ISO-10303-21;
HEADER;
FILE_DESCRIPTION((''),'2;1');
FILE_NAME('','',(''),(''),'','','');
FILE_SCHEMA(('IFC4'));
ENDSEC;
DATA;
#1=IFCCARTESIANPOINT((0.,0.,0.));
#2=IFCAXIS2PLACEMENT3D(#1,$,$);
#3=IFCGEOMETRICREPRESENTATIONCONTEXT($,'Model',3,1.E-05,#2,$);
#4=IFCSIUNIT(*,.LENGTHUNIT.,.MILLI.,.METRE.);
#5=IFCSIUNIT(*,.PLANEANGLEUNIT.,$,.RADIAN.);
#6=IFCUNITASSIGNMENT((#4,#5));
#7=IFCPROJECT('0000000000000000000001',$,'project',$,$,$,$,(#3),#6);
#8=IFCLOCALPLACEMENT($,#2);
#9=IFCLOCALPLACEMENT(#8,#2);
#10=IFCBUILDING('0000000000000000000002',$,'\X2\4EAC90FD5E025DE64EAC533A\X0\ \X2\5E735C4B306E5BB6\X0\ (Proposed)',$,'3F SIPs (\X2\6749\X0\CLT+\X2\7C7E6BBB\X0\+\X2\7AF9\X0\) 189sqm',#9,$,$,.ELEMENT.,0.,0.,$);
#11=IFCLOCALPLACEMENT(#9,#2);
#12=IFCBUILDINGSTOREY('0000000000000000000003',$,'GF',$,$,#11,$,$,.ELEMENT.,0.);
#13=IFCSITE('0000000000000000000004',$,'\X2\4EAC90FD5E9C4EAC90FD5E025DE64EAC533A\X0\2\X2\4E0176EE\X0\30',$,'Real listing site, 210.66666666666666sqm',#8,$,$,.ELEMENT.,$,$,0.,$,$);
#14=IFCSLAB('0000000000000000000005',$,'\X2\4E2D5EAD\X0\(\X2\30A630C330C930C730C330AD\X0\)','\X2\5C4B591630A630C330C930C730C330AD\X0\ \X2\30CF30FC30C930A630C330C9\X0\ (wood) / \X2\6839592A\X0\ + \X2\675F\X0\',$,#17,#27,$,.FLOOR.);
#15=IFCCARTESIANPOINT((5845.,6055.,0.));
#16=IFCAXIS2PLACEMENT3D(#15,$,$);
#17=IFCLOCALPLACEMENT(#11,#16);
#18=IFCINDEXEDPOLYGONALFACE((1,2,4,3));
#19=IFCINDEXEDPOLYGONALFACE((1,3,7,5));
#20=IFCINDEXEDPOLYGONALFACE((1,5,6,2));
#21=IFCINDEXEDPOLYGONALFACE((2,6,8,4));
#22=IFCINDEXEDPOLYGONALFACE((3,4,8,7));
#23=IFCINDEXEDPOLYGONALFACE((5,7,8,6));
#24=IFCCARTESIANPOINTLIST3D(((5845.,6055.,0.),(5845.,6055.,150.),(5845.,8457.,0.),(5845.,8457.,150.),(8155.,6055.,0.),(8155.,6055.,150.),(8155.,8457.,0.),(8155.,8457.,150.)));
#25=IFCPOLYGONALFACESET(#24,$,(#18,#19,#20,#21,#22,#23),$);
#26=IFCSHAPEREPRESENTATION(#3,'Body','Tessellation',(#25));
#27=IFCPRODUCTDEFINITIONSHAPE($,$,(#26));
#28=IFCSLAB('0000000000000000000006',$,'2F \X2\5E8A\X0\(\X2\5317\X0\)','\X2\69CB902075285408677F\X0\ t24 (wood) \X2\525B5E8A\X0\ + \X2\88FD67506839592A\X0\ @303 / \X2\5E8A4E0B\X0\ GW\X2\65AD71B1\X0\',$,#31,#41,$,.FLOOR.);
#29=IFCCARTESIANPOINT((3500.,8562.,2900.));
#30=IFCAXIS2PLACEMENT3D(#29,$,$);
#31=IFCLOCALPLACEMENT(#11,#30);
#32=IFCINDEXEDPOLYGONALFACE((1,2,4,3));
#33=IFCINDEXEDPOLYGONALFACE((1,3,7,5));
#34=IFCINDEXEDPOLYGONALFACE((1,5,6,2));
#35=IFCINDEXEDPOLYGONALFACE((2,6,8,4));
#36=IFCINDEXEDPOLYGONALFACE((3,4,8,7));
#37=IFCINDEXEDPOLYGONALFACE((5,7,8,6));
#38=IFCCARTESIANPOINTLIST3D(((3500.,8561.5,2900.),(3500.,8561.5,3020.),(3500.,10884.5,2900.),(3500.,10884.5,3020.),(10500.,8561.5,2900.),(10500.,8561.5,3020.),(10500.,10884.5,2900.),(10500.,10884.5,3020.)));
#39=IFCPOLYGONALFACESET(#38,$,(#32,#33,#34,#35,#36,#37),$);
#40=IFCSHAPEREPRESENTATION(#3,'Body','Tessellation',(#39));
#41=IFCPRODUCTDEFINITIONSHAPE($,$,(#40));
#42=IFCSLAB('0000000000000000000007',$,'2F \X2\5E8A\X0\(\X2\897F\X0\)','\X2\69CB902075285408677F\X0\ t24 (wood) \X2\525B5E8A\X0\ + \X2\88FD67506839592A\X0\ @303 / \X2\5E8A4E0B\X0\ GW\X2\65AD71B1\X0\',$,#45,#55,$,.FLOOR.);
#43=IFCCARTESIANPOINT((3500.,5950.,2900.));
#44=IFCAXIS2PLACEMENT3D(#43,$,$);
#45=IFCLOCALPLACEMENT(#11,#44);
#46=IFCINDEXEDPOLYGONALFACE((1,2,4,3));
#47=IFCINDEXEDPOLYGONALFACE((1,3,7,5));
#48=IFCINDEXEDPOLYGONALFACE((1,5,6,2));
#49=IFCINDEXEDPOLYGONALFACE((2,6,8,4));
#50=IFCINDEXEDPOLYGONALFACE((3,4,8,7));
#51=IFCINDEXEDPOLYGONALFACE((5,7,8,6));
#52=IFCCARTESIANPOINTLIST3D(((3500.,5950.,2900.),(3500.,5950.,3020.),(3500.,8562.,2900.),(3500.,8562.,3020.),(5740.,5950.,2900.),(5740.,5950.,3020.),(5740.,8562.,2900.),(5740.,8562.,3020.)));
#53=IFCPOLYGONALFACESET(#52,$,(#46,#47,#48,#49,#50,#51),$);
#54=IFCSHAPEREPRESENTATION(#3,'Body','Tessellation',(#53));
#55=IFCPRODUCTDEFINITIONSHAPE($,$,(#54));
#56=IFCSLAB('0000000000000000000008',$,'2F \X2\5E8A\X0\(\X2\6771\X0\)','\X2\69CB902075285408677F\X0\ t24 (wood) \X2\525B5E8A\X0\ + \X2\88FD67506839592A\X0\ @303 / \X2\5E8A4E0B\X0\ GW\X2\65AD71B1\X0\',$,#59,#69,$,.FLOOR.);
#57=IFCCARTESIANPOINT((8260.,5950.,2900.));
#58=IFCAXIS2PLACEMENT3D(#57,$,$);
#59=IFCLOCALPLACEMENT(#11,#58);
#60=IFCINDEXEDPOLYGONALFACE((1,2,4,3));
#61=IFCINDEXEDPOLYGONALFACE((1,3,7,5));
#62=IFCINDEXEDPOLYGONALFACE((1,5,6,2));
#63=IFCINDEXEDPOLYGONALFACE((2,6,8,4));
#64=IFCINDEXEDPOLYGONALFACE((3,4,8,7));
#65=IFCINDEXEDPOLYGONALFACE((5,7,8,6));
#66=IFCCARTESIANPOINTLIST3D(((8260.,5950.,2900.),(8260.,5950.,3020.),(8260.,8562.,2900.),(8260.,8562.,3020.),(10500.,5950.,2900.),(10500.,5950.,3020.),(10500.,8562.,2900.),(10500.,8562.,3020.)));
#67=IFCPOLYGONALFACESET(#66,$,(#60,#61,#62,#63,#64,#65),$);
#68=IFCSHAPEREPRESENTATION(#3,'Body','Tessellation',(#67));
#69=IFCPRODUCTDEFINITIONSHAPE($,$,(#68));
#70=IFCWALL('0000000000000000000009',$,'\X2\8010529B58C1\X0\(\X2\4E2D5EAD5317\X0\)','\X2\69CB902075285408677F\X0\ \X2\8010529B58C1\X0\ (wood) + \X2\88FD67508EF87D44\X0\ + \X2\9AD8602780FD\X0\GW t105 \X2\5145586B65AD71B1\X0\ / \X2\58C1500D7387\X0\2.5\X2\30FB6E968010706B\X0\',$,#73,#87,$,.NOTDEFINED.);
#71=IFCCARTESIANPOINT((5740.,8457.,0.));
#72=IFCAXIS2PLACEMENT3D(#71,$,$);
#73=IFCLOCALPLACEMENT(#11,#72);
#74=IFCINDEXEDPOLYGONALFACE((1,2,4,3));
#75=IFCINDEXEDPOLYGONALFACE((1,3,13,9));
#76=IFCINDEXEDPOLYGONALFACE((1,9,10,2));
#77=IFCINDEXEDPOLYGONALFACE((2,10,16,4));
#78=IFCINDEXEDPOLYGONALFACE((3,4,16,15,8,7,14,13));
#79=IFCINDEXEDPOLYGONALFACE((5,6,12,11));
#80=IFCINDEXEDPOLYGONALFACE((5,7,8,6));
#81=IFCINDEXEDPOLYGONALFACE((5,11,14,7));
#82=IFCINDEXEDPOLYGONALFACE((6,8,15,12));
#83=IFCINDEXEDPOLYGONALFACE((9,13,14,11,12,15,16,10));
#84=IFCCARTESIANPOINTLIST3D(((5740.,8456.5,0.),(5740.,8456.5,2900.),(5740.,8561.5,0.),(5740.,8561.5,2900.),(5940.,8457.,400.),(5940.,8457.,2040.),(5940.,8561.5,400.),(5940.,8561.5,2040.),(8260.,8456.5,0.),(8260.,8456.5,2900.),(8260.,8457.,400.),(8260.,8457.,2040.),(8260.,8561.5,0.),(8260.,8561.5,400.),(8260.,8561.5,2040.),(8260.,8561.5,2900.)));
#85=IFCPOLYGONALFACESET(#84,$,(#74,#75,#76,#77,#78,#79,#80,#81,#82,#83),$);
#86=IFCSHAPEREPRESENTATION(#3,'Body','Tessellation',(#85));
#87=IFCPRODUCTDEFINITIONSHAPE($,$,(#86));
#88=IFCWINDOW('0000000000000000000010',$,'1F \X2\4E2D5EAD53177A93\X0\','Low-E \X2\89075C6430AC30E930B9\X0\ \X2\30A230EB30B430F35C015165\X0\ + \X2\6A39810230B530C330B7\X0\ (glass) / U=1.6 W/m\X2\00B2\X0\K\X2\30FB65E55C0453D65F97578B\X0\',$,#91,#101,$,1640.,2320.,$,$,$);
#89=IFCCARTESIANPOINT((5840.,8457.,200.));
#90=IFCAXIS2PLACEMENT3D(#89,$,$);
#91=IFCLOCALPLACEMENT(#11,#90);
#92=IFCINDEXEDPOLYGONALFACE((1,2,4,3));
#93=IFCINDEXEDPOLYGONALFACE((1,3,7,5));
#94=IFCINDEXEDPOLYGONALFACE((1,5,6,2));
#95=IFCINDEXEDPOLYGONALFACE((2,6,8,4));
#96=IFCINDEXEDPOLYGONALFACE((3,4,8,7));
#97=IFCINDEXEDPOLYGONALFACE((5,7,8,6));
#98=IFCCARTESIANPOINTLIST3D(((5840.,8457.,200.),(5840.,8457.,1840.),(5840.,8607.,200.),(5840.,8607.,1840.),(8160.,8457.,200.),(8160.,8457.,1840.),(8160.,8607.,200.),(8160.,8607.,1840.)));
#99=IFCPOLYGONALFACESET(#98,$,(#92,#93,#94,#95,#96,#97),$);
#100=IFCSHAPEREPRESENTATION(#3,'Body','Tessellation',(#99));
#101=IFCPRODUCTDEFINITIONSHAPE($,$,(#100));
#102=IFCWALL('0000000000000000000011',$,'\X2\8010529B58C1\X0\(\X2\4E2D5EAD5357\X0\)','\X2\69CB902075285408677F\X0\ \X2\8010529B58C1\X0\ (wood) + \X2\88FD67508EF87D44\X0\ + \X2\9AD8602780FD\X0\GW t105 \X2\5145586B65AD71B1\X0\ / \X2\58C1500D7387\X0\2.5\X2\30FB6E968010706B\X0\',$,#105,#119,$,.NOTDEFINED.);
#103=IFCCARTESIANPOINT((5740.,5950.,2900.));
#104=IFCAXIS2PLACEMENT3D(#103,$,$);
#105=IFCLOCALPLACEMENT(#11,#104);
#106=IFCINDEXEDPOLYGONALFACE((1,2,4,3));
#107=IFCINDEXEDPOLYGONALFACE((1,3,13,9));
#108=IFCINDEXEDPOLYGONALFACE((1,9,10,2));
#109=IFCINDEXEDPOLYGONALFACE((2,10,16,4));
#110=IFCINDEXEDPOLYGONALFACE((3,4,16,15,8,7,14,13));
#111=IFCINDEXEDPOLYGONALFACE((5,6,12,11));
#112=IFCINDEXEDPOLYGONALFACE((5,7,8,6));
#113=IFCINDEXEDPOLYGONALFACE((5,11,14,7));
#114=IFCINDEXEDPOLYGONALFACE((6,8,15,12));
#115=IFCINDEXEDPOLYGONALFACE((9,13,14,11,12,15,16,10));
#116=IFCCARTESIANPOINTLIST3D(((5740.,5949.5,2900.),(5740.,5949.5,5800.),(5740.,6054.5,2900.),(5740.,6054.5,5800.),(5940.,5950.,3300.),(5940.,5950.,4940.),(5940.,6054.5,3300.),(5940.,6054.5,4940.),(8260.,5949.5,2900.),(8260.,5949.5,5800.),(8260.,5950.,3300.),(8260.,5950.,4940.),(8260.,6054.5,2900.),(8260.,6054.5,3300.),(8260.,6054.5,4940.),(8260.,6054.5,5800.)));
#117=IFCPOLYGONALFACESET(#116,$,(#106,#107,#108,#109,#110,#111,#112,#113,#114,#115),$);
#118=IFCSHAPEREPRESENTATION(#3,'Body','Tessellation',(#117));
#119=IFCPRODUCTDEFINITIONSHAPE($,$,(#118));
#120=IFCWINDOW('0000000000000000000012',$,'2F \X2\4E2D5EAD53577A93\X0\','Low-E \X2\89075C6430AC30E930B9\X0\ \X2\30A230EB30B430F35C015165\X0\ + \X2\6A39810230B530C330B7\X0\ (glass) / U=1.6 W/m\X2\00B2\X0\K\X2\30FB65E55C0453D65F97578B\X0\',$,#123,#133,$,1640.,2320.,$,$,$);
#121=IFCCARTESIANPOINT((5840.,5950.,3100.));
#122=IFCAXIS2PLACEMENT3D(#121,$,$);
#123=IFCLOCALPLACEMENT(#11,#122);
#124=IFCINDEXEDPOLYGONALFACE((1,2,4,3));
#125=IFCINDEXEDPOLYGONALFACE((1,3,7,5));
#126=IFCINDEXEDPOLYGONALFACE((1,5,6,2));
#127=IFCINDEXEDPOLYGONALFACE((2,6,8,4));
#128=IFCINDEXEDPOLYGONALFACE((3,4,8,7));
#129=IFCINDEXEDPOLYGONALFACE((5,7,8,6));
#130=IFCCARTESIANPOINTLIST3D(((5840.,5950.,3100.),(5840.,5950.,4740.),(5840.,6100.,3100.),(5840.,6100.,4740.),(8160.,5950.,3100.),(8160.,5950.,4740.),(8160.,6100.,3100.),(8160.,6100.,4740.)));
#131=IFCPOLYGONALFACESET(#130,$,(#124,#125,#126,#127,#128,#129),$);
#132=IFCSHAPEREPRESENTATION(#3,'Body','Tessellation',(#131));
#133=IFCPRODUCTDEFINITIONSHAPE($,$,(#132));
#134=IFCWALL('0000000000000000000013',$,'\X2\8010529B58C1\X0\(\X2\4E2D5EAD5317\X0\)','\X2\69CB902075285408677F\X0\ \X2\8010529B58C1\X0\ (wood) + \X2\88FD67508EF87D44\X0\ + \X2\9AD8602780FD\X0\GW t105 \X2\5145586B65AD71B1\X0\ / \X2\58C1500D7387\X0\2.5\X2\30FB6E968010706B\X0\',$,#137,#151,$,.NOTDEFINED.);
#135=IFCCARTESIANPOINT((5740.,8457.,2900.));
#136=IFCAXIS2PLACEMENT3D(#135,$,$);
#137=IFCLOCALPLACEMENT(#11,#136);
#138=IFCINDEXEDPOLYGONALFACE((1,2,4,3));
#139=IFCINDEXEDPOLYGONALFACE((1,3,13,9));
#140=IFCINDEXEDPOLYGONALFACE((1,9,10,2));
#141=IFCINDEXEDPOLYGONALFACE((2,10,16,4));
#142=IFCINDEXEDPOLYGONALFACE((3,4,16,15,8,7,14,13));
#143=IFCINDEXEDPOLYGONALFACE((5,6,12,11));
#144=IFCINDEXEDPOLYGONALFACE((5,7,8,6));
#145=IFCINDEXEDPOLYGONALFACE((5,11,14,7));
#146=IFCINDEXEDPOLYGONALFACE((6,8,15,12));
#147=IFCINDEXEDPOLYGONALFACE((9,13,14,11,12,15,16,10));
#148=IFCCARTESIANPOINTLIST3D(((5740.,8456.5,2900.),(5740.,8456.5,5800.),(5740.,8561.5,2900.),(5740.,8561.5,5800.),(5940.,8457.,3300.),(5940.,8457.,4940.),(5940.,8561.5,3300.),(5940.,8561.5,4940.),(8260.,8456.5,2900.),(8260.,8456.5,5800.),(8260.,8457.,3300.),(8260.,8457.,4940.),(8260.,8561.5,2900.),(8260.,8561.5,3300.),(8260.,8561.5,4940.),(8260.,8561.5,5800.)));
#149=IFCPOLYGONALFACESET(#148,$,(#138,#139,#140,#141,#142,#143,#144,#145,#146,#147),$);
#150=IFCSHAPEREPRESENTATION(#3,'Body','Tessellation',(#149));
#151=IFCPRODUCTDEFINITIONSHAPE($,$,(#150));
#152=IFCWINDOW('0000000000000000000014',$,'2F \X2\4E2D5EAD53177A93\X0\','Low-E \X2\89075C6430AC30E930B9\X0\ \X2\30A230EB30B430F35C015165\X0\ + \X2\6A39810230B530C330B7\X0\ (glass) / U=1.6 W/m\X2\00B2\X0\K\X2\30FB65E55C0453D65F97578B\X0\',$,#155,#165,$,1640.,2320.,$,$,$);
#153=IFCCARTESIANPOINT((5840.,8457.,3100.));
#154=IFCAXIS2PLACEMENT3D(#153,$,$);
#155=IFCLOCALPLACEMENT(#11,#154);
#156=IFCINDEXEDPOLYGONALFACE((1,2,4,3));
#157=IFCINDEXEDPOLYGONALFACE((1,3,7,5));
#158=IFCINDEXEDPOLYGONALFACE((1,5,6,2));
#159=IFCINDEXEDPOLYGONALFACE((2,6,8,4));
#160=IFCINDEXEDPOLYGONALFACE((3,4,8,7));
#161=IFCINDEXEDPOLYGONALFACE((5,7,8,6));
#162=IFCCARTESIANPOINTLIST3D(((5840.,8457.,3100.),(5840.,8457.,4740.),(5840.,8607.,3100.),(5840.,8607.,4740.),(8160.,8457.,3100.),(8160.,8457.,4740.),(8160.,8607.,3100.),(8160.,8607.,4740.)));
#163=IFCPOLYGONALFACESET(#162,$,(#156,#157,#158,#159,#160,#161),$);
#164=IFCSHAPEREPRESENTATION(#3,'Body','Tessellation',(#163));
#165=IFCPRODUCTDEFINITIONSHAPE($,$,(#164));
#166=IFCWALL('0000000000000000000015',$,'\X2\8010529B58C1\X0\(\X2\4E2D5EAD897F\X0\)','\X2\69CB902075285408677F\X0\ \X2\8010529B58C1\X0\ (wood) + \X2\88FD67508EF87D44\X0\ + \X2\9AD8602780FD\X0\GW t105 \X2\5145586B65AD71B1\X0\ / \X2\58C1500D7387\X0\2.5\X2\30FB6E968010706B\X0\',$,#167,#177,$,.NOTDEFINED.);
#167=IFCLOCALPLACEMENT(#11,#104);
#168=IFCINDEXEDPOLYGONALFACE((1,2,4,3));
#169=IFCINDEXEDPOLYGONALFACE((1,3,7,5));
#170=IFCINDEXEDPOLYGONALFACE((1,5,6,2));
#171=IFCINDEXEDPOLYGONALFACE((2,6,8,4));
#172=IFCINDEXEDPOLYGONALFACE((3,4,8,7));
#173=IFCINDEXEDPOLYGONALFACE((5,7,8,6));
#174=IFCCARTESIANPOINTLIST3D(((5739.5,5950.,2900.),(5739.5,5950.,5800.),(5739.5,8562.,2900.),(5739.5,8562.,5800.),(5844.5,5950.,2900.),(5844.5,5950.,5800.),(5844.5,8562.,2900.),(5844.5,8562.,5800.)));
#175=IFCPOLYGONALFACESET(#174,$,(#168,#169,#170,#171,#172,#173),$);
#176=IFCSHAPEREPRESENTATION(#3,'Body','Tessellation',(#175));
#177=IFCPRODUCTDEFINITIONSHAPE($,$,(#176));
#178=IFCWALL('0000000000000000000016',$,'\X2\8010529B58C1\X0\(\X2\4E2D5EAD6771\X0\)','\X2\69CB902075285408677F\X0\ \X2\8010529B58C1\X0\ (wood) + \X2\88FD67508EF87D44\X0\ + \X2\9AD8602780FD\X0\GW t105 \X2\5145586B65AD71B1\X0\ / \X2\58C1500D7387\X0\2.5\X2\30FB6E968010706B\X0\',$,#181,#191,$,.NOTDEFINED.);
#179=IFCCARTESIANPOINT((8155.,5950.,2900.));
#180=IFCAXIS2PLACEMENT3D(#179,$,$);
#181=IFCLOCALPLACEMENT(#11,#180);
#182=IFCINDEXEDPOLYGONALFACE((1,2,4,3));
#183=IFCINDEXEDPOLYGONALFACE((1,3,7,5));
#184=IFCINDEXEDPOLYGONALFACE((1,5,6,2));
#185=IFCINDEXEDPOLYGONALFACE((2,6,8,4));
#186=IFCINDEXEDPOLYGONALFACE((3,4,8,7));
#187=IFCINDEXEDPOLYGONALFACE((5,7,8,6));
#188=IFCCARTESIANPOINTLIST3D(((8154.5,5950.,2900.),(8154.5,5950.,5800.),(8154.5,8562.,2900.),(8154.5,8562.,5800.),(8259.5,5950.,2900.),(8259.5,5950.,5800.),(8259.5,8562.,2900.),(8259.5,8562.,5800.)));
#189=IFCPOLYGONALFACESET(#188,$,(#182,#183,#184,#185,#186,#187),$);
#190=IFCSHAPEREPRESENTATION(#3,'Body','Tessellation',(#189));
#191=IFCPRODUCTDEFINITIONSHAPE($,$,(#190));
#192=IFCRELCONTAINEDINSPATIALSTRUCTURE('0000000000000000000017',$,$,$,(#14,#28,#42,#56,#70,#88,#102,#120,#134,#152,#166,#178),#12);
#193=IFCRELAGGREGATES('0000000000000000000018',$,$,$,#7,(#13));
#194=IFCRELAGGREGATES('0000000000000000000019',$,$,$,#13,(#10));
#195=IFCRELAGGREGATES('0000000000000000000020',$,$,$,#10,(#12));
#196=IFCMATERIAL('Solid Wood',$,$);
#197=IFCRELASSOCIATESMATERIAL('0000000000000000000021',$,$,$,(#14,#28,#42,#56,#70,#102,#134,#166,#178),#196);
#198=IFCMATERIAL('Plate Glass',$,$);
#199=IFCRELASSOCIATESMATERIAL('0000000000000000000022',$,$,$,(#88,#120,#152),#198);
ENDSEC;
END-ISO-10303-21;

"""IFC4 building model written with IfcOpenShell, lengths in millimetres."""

from ifc_helpers import new_model, si_unit, frame, frame_2d, origin, place, context, project, spatial, rectangle, extrude, material, element, fill, save


model = new_model("IFC4")

# Units and contexts
model_context = context("Model", 3, precision=1e-05, world=origin())
ifc_project = project(units=[si_unit("LENGTHUNIT", "METRE", prefix="MILLI"), si_unit("PLANEANGLEUNIT", "RADIAN")], contexts=[model_context])

# Site, building, storey
site_placement = place(None, origin())
site = spatial("IfcSite", under=ifc_project, at=site_placement, Name="京都府京都市左京区2丁目30", ObjectType="Real listing site, 210.66666666666666sqm", CompositionType="ELEMENT", RefElevation=0.0)
building_placement = place(site_placement, origin())
building = spatial("IfcBuilding", under=site, at=building_placement, Name="京都市左京区 平屋の家 (Proposed)", ObjectType="3F SIPs (杉CLT+籾殻+竹) 189sqm", CompositionType="ELEMENT", ElevationOfRefHeight=0.0, ElevationOfTerrain=0.0)
storey_placement = place(building_placement, origin())
storey = spatial("IfcBuildingStorey", under=building, at=storey_placement, Name="GF", CompositionType="ELEMENT", Elevation=0.0)

# Slabs
ifc_material_1 = material(Name="Solid Wood")
slab_1_placement = place(storey_placement, frame((5845.0, 6055.0, 0.0)))
element("IfcSlab", 1, at=slab_1_placement, inside=storey, material=ifc_material_1, Name="中庭(ウッドデッキ)", Description="屋外ウッドデッキ ハードウッド (wood) / 根太 + 束", PredefinedType="FLOOR", context=model_context, shape_type="SweptSolid", body=[
    extrude(rectangle(XDim=2310.0, YDim=2402.0, at=frame_2d((1155.0, 1201.0))), frame((5845.0, 6055.0, 0.0)), (0.0, 0.0, 1.0), 150.0),
])
slab_2_placement = place(storey_placement, frame((3500.0, 8562.0, 2900.0)))
element("IfcSlab", 2, at=slab_2_placement, inside=storey, material=ifc_material_1, Name="2F 床(北)", Description="構造用合板 t24 (wood) 剛床 + 製材根太 @303 / 床下 GW断熱", PredefinedType="FLOOR", context=model_context, shape_type="SweptSolid", body=[
    extrude(rectangle(XDim=7000.0, YDim=2323.0, at=frame_2d((3500.0, 1161.0))), frame((3500.0, 8562.0, 2900.0)), (0.0, 0.0, 1.0), 120.0),
])
slab_3_placement = place(storey_placement, frame((3500.0, 5950.0, 2900.0)))
element("IfcSlab", 3, at=slab_3_placement, inside=storey, material=ifc_material_1, Name="2F 床(西)", Description="構造用合板 t24 (wood) 剛床 + 製材根太 @303 / 床下 GW断熱", PredefinedType="FLOOR", context=model_context, shape_type="SweptSolid", body=[
    extrude(rectangle(XDim=2240.0, YDim=2612.0, at=frame_2d((1120.0, 1306.0))), frame((3500.0, 5950.0, 2900.0)), (0.0, 0.0, 1.0), 120.0),
])
slab_4_placement = place(storey_placement, frame((8260.0, 5950.0, 2900.0)))
element("IfcSlab", 4, at=slab_4_placement, inside=storey, material=ifc_material_1, Name="2F 床(東)", Description="構造用合板 t24 (wood) 剛床 + 製材根太 @303 / 床下 GW断熱", PredefinedType="FLOOR", context=model_context, shape_type="SweptSolid", body=[
    extrude(rectangle(XDim=2240.0, YDim=2612.0, at=frame_2d((1120.0, 1306.0))), frame((8260.0, 5950.0, 2900.0)), (0.0, 0.0, 1.0), 120.0),
])

# Wall, opening, window
wall_1_placement = place(storey_placement, frame((5740.0, 8457.0, 0.0)))
wall_1 = element("IfcWall", 5, at=wall_1_placement, inside=storey, material=ifc_material_1, Name="耐力壁(中庭北)", Description="構造用合板 耐力壁 (wood) + 製材軸組 + 高性能GW t105 充填断熱 / 壁倍率2.5・準耐火", PredefinedType="NOTDEFINED", context=model_context, shape_type="SweptSolid", body=[
    extrude(rectangle(XDim=2520.0, YDim=105.0, at=frame_2d((1260.0, 52.0))), frame((5740.0, 8457.0, 0.0)), (0.0, 0.0, 1.0), 2900.0),
])
opening_1_placement = place(storey_placement, frame((5840.0, 8457.0, 200.0)))
opening_1 = element("IfcOpeningElement", 6, at=opening_1_placement, cuts=wall_1, PredefinedType="NOTDEFINED", context=model_context, shape_type="SweptSolid", body=[
    extrude(rectangle(XDim=2320.0, YDim=150.0, at=frame_2d((1160.0, 75.0))), frame((5840.0, 8457.0, 200.0)), (0.0, 0.0, 1.0), 1640.0),
])
ifc_material_2 = material(Name="Plate Glass")
window_1_placement = place(storey_placement, frame((5840.0, 8457.0, 200.0)))
window_1 = element("IfcWindow", 7, at=window_1_placement, inside=storey, material=ifc_material_2, Name="1F 中庭北窓", Description="Low-E 複層ガラス アルゴン封入 + 樹脂サッシ (glass) / U=1.6 W/m²K・日射取得型", OverallHeight=1640.0, OverallWidth=2320.0, context=model_context, shape_type="SweptSolid", body=[
    extrude(rectangle(XDim=2320.0, YDim=150.0, at=frame_2d((1160.0, 75.0))), frame((5840.0, 8457.0, 200.0)), (0.0, 0.0, 1.0), 1640.0),
])
fill(opening_1, window_1)

# Walls, openings, windows
wall_2_placement = place(storey_placement, frame((5740.0, 5950.0, 2900.0)))
wall_2 = element("IfcWall", 8, at=wall_2_placement, inside=storey, material=ifc_material_1, Name="耐力壁(中庭南)", Description="構造用合板 耐力壁 (wood) + 製材軸組 + 高性能GW t105 充填断熱 / 壁倍率2.5・準耐火", PredefinedType="NOTDEFINED", context=model_context, shape_type="SweptSolid", body=[
    extrude(rectangle(XDim=2520.0, YDim=105.0, at=frame_2d((1260.0, 52.0))), frame((5740.0, 5950.0, 2900.0)), (0.0, 0.0, 1.0), 2900.0),
])
opening_2_placement = place(storey_placement, frame((5840.0, 5950.0, 3100.0)))
opening_2 = element("IfcOpeningElement", 9, at=opening_2_placement, cuts=wall_2, PredefinedType="NOTDEFINED", context=model_context, shape_type="SweptSolid", body=[
    extrude(rectangle(XDim=2320.0, YDim=150.0, at=frame_2d((1160.0, 75.0))), frame((5840.0, 5950.0, 3100.0)), (0.0, 0.0, 1.0), 1640.0),
])
window_2_placement = place(storey_placement, frame((5840.0, 5950.0, 3100.0)))
window_2 = element("IfcWindow", 10, at=window_2_placement, inside=storey, material=ifc_material_2, Name="2F 中庭南窓", Description="Low-E 複層ガラス アルゴン封入 + 樹脂サッシ (glass) / U=1.6 W/m²K・日射取得型", OverallHeight=1640.0, OverallWidth=2320.0, context=model_context, shape_type="SweptSolid", body=[
    extrude(rectangle(XDim=2320.0, YDim=150.0, at=frame_2d((1160.0, 75.0))), frame((5840.0, 5950.0, 3100.0)), (0.0, 0.0, 1.0), 1640.0),
])
fill(opening_2, window_2)
wall_3_placement = place(storey_placement, frame((5740.0, 8457.0, 2900.0)))
wall_3 = element("IfcWall", 11, at=wall_3_placement, inside=storey, material=ifc_material_1, Name="耐力壁(中庭北)", Description="構造用合板 耐力壁 (wood) + 製材軸組 + 高性能GW t105 充填断熱 / 壁倍率2.5・準耐火", PredefinedType="NOTDEFINED", context=model_context, shape_type="SweptSolid", body=[
    extrude(rectangle(XDim=2520.0, YDim=105.0, at=frame_2d((1260.0, 52.0))), frame((5740.0, 8457.0, 2900.0)), (0.0, 0.0, 1.0), 2900.0),
])
opening_3_placement = place(storey_placement, frame((5840.0, 8457.0, 3100.0)))
opening_3 = element("IfcOpeningElement", 12, at=opening_3_placement, cuts=wall_3, PredefinedType="NOTDEFINED", context=model_context, shape_type="SweptSolid", body=[
    extrude(rectangle(XDim=2320.0, YDim=150.0, at=frame_2d((1160.0, 75.0))), frame((5840.0, 8457.0, 3100.0)), (0.0, 0.0, 1.0), 1640.0),
])
window_3_placement = place(storey_placement, frame((5840.0, 8457.0, 3100.0)))
window_3 = element("IfcWindow", 13, at=window_3_placement, inside=storey, material=ifc_material_2, Name="2F 中庭北窓", Description="Low-E 複層ガラス アルゴン封入 + 樹脂サッシ (glass) / U=1.6 W/m²K・日射取得型", OverallHeight=1640.0, OverallWidth=2320.0, context=model_context, shape_type="SweptSolid", body=[
    extrude(rectangle(XDim=2320.0, YDim=150.0, at=frame_2d((1160.0, 75.0))), frame((5840.0, 8457.0, 3100.0)), (0.0, 0.0, 1.0), 1640.0),
])
fill(opening_3, window_3)

# Walls
wall_4_placement = place(storey_placement, frame((5740.0, 5950.0, 2900.0)))
element("IfcWall", 14, at=wall_4_placement, inside=storey, material=ifc_material_1, Name="耐力壁(中庭西)", Description="構造用合板 耐力壁 (wood) + 製材軸組 + 高性能GW t105 充填断熱 / 壁倍率2.5・準耐火", PredefinedType="NOTDEFINED", context=model_context, shape_type="SweptSolid", body=[
    extrude(rectangle(XDim=105.0, YDim=2612.0, at=frame_2d((52.0, 1306.0))), frame((5740.0, 5950.0, 2900.0)), (0.0, 0.0, 1.0), 2900.0),
])
wall_5_placement = place(storey_placement, frame((8155.0, 5950.0, 2900.0)))
element("IfcWall", 15, at=wall_5_placement, inside=storey, material=ifc_material_1, Name="耐力壁(中庭東)", Description="構造用合板 耐力壁 (wood) + 製材軸組 + 高性能GW t105 充填断熱 / 壁倍率2.5・準耐火", PredefinedType="NOTDEFINED", context=model_context, shape_type="SweptSolid", body=[
    extrude(rectangle(XDim=105.0, YDim=2612.0, at=frame_2d((52.0, 1306.0))), frame((8155.0, 5950.0, 2900.0)), (0.0, 0.0, 1.0), 2900.0),
])

save(model, "model.ifc")
